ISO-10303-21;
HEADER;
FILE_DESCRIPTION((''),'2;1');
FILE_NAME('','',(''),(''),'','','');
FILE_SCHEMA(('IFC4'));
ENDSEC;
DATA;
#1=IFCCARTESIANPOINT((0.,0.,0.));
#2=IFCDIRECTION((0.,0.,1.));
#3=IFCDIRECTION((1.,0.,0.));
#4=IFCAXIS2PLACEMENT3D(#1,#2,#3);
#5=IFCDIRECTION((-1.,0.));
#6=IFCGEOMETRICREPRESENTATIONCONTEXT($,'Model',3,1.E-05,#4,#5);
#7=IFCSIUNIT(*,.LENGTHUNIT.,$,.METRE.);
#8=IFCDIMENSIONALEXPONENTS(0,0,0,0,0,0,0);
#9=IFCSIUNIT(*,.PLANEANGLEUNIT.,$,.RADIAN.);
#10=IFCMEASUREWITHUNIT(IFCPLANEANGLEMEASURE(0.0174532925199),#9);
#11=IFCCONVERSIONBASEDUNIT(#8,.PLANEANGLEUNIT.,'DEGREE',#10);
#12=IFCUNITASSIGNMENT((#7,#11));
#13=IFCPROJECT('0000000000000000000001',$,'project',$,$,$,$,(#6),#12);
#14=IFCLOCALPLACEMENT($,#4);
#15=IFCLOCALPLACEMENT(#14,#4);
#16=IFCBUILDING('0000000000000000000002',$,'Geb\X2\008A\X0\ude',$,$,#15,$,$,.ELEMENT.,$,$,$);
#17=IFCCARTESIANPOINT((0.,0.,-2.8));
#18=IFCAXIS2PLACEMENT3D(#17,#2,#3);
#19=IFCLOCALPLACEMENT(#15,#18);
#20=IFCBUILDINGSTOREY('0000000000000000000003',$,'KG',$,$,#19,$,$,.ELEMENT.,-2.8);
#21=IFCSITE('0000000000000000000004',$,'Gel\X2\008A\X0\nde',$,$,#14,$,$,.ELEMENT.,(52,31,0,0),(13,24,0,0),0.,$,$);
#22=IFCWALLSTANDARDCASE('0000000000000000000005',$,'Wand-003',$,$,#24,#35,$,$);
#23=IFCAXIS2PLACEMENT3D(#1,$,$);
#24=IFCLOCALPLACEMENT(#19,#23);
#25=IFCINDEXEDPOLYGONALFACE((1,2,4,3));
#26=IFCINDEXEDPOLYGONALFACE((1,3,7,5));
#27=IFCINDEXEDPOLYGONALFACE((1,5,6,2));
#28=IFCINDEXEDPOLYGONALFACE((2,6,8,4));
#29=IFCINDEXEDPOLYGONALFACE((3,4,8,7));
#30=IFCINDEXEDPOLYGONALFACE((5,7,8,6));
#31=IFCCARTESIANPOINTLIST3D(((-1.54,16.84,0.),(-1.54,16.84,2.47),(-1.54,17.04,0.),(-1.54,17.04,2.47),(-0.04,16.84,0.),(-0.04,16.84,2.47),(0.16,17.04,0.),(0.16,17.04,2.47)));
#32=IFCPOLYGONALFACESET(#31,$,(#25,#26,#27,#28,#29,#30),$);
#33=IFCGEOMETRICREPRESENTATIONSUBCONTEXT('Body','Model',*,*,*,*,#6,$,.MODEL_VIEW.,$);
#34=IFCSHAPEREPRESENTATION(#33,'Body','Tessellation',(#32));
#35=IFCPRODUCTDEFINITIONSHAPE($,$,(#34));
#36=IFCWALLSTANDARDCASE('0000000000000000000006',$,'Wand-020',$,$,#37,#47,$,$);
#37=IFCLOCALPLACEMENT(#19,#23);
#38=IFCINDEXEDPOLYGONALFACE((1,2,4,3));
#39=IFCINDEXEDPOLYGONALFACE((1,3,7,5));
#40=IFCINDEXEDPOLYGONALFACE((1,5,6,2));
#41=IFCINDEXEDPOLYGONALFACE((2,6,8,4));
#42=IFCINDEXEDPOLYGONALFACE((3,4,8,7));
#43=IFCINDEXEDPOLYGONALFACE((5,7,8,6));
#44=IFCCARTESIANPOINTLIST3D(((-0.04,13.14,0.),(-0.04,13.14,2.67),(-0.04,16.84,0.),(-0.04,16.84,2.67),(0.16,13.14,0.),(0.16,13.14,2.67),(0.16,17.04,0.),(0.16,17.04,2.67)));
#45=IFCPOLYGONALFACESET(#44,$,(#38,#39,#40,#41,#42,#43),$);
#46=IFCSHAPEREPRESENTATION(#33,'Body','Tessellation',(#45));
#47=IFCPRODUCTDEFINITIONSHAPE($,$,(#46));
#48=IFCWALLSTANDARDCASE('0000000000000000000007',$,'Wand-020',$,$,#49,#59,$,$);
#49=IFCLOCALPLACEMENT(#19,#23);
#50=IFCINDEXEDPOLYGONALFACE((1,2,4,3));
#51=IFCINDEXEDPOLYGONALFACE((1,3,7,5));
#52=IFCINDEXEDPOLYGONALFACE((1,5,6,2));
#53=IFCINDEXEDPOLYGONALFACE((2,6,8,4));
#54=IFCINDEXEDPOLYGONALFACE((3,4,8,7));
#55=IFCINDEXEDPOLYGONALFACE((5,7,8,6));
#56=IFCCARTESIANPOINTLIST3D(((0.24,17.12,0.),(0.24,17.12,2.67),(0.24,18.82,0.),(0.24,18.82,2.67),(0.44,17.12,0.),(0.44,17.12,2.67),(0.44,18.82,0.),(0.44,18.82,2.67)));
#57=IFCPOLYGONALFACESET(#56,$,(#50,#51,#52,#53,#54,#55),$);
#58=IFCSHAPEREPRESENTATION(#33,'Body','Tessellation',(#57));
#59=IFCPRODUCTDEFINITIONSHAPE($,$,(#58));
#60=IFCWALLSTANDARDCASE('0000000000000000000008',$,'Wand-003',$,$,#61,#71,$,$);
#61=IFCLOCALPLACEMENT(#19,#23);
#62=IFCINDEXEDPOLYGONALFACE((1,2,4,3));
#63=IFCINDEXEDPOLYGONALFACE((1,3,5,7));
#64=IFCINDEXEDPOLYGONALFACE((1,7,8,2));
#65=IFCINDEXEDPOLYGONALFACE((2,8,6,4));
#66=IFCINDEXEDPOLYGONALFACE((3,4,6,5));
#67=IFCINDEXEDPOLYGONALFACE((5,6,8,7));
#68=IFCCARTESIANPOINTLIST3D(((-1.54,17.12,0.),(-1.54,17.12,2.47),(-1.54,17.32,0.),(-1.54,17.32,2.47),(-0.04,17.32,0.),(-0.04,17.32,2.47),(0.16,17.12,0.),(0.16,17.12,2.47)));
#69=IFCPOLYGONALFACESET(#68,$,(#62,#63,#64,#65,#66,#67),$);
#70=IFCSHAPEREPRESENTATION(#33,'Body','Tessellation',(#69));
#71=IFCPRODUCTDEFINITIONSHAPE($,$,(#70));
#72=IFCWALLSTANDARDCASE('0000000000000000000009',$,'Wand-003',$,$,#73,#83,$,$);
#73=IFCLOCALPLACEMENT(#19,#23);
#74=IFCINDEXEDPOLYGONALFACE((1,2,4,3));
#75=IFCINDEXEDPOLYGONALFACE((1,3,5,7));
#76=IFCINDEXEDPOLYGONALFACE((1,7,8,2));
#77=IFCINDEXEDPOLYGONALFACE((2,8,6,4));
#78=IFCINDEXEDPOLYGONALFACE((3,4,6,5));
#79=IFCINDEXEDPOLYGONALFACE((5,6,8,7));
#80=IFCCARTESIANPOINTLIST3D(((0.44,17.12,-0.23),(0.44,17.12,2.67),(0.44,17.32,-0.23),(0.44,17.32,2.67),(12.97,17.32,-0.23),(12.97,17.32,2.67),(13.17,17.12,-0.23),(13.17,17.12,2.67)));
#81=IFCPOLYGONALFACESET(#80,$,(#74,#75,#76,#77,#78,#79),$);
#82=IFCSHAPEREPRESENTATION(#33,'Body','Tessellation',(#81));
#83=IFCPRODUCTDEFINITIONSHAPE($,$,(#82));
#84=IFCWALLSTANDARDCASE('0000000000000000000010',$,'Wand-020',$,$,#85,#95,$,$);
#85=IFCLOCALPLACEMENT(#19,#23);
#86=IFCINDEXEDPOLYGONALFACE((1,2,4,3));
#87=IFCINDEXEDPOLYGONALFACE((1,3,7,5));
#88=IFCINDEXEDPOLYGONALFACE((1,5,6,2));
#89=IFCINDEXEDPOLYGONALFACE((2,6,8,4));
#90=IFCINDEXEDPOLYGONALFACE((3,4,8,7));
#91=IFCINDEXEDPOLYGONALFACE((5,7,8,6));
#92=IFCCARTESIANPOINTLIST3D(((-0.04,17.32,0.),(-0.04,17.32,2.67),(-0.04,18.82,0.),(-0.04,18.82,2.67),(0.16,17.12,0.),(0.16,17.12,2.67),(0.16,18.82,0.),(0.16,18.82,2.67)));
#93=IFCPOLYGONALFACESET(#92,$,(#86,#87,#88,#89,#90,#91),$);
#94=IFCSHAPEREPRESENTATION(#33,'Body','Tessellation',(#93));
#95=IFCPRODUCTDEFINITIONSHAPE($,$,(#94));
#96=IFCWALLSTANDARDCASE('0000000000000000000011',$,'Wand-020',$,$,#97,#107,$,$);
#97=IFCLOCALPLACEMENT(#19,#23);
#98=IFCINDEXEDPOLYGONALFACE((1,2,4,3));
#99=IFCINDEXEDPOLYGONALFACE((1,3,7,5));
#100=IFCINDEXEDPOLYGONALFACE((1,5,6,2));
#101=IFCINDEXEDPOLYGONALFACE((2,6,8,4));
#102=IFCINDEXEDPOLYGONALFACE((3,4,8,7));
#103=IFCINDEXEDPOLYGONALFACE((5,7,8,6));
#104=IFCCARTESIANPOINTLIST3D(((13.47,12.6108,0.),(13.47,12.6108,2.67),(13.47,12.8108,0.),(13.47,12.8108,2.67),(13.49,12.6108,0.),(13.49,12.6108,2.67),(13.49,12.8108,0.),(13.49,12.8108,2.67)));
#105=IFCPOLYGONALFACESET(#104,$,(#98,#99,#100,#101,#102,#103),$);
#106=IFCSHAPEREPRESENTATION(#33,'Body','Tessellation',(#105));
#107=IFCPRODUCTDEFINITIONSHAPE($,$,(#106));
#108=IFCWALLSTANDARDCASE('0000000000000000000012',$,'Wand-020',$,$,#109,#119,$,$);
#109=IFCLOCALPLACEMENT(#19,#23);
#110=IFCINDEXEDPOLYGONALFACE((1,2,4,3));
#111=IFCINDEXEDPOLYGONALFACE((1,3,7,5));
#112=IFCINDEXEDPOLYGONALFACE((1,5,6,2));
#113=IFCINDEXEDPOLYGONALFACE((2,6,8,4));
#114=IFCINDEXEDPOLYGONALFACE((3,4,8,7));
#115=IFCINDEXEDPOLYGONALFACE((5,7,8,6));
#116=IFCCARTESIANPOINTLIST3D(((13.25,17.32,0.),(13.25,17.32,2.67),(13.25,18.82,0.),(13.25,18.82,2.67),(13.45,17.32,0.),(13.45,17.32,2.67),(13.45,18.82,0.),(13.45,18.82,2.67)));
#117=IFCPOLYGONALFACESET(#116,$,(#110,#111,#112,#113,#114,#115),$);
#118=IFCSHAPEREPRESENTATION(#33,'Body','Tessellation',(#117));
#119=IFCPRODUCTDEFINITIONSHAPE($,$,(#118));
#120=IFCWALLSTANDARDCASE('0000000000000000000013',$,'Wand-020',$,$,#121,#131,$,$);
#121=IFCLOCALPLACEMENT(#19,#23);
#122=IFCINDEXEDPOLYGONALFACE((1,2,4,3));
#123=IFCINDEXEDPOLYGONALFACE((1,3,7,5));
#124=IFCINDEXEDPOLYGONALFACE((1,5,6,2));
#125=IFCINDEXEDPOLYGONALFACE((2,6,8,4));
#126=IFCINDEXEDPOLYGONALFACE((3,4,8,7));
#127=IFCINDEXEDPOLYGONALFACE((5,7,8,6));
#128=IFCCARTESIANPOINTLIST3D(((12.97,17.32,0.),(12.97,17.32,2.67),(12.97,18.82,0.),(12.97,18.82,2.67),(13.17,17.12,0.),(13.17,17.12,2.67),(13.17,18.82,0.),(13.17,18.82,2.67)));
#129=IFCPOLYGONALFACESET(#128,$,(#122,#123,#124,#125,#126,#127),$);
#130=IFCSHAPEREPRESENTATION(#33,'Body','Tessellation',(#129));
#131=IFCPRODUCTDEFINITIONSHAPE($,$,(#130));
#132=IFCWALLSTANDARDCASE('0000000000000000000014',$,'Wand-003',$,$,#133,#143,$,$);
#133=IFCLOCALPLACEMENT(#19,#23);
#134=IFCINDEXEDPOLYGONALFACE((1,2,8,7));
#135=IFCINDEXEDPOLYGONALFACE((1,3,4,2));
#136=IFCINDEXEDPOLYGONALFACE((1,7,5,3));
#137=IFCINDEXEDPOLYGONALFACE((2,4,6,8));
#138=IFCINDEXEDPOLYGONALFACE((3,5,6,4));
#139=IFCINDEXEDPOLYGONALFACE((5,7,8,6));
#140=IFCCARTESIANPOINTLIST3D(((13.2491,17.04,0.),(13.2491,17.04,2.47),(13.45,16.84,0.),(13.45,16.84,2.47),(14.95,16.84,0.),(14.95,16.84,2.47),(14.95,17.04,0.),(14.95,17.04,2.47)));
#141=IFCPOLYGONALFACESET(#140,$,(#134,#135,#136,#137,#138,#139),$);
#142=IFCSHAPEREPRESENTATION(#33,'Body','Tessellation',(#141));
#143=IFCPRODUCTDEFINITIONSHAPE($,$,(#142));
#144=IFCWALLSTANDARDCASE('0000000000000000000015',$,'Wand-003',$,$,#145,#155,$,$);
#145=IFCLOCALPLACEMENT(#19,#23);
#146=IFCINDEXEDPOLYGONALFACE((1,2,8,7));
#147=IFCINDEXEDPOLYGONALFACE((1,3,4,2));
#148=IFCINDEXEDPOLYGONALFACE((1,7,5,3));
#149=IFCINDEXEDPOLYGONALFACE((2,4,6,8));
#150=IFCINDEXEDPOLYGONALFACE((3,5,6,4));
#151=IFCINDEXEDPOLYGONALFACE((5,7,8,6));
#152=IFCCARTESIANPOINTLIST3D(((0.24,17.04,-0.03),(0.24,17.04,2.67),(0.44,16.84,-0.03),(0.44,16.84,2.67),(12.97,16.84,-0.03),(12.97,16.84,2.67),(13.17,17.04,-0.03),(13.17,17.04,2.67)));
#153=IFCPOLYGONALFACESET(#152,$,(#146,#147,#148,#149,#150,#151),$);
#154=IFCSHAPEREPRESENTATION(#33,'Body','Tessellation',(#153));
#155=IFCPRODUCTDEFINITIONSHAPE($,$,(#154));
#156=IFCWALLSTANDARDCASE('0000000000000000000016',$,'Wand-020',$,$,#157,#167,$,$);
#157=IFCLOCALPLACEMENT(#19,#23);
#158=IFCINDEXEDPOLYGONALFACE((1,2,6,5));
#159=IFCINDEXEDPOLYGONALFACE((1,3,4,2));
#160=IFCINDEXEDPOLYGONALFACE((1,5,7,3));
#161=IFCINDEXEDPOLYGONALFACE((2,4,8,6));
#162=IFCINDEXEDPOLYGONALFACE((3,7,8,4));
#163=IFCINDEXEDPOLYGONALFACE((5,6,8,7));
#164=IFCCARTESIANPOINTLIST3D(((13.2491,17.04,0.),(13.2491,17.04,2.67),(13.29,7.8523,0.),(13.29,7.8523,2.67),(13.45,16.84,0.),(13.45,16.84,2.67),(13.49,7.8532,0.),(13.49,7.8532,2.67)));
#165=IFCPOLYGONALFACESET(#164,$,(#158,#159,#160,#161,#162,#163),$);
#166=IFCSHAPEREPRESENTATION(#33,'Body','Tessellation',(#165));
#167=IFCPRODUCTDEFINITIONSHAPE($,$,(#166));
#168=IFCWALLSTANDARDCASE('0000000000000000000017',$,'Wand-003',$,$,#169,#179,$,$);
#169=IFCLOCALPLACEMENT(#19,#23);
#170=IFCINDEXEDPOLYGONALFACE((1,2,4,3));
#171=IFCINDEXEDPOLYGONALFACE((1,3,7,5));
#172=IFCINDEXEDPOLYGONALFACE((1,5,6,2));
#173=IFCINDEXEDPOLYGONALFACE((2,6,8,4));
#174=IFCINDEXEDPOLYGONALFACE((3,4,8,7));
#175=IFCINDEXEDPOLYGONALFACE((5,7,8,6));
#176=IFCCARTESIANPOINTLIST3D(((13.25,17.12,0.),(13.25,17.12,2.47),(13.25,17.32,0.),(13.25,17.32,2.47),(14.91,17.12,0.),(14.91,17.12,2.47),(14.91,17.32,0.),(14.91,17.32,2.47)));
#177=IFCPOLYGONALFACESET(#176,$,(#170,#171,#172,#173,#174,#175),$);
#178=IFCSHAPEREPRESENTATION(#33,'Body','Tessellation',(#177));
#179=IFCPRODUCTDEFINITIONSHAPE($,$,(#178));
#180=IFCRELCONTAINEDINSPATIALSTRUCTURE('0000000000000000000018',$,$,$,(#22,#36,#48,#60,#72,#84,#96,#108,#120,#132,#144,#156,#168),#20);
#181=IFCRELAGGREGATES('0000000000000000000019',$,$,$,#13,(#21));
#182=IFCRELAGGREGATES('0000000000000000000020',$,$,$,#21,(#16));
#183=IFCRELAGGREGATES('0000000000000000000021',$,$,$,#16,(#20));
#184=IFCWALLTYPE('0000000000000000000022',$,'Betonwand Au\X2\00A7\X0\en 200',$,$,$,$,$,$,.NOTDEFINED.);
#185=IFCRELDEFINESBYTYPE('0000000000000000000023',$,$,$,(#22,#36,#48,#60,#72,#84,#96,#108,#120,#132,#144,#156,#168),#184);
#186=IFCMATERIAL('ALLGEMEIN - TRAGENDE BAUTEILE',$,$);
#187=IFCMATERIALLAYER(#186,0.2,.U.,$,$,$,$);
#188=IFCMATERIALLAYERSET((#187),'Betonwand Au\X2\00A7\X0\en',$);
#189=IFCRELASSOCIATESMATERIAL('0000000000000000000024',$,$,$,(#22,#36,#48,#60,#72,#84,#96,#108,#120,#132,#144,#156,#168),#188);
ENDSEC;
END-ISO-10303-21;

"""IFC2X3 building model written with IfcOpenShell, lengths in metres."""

from ifc_helpers import new_model, entity, si_unit, converted_unit, direction, frame, origin_with_axes, place, context, subcontext, project, spatial, polyline, outline, extrude, material, layer, layer_set, layer_usage, type_object, element, save


model = new_model("IFC2X3")

# Units and contexts
model_context = context("Model", 3, precision=1e-05, world=origin_with_axes(), true_north=direction((-1.0, 0.0)))
body_context = subcontext(model_context, "Body", "Model", "MODEL_VIEW")
ifc_project = project(units=[si_unit("LENGTHUNIT", "METRE"), converted_unit("PLANEANGLEUNIT", "DEGREE", entity("IfcPlaneAngleMeasure", 0.0174532925199), si_unit("PLANEANGLEUNIT", "RADIAN"), dimensions=[0, 0, 0, 0, 0, 0, 0])], contexts=[model_context])

# Site, building, storey
site_placement = place(None, origin_with_axes())
site = spatial("IfcSite", under=ifc_project, at=site_placement, Name="Gel\u008ande", CompositionType="ELEMENT", RefLatitude=(52, 31, 0, 0), RefLongitude=(13, 24, 0, 0), RefElevation=0.0)
building_placement = place(site_placement, origin_with_axes())
building = spatial("IfcBuilding", under=site, at=building_placement, Name="Geb\u008aude", CompositionType="ELEMENT")
storey_placement = place(building_placement, frame((0.0, 0.0, -2.8), z_axis=(0.0, 0.0, 1.0), x_axis=(1.0, 0.0, 0.0)))
storey = spatial("IfcBuildingStorey", under=building, at=storey_placement, Name="KG", CompositionType="ELEMENT", Elevation=-2.8)

# Shared definitions
ifc_material_1 = material(Name="ALLGEMEIN - TRAGENDE BAUTEILE")

# Walls
ifc_layer_1 = layer(ifc_material_1, 0.2, ventilated="UNKNOWN")
ifc_layer_set_1 = layer_set([ifc_layer_1], Name="Betonwand Au§en")
wall_type_1 = type_object("IfcWallType", Name="Betonwand Au§en 200", PredefinedType="NOTDEFINED")
ifc_layer_usage_1 = layer_usage(ifc_layer_set_1, "AXIS2", "POSITIVE", 0.0)
wall_1_placement = place(storey_placement, frame((-1.54, 16.84, 0.0), z_axis=(0.0, 0.0, 1.0), x_axis=(1.0, 0.0, 0.0)))
element("IfcWallStandardCase", 1, at=wall_1_placement, inside=storey, type_object=wall_type_1, material=ifc_layer_usage_1, Name="Wand-003", context=body_context, shape_type="SweptSolid", body=[
    extrude(outline(polyline([(0.0, 0.0), (1.5, 0.0), (1.7, 0.2), (0.0, 0.2), (0.0, 0.0)])), origin_with_axes(), (0.0, 0.0, 1.0), 2.47),
])
ifc_layer_usage_2 = layer_usage(ifc_layer_set_1, "AXIS2", "POSITIVE", -0.2)
wall_2_placement = place(storey_placement, frame((-0.04, 13.14, 0.0), z_axis=(0.0, 0.0, 1.0), x_axis=(0.0, 1.0, 0.0)))
element("IfcWallStandardCase", 2, at=wall_2_placement, inside=storey, type_object=wall_type_1, material=ifc_layer_usage_2, Name="Wand-020", context=body_context, shape_type="SweptSolid", body=[
    extrude(outline(polyline([(0.0, -0.2), (3.9, -0.2), (3.7, 0.0), (0.0, 0.0), (0.0, -0.2)])), origin_with_axes(), (0.0, 0.0, 1.0), 2.67),
])
ifc_layer_usage_3 = layer_usage(ifc_layer_set_1, "AXIS2", "NEGATIVE", 0.2)
wall_3_placement = place(storey_placement, frame((0.44, 17.12, 0.0), z_axis=(0.0, 0.0, 1.0), x_axis=(0.0, 1.0, 0.0)))
element("IfcWallStandardCase", 3, at=wall_3_placement, inside=storey, type_object=wall_type_1, material=ifc_layer_usage_3, Name="Wand-020", context=body_context, shape_type="SweptSolid", body=[
    extrude(outline(polyline([(0.0, 0.0), (1.7, 0.0), (1.7, 0.2), (0.0, 0.2), (0.0, 0.0)])), origin_with_axes(), (0.0, 0.0, 1.0), 2.67),
])
ifc_layer_usage_4 = layer_usage(ifc_layer_set_1, "AXIS2", "POSITIVE", 0.0)
wall_4_placement = place(storey_placement, frame((-1.54, 17.12, 0.0), z_axis=(0.0, 0.0, 1.0), x_axis=(1.0, 0.0, 0.0)))
element("IfcWallStandardCase", 4, at=wall_4_placement, inside=storey, type_object=wall_type_1, material=ifc_layer_usage_4, Name="Wand-003", context=body_context, shape_type="SweptSolid", body=[
    extrude(outline(polyline([(0.0, 0.0), (1.7, 0.0), (1.5, 0.2), (0.0, 0.2), (0.0, 0.0)])), origin_with_axes(), (0.0, 0.0, 1.0), 2.47),
])
ifc_layer_usage_5 = layer_usage(ifc_layer_set_1, "AXIS2", "NEGATIVE", 0.0)
wall_5_placement = place(storey_placement, frame((0.44, 17.32, -0.23), z_axis=(0.0, 0.0, 1.0), x_axis=(1.0, 0.0, 0.0)))
element("IfcWallStandardCase", 5, at=wall_5_placement, inside=storey, type_object=wall_type_1, material=ifc_layer_usage_5, Name="Wand-003", context=body_context, shape_type="SweptSolid", body=[
    extrude(outline(polyline([(0.0, -0.2), (12.73, -0.2), (12.53, 0.0), (0.0, 0.0), (0.0, -0.2)])), origin_with_axes(), (0.0, 0.0, 1.0), 2.9),
])
ifc_layer_usage_6 = layer_usage(ifc_layer_set_1, "AXIS2", "NEGATIVE", 0.2)
wall_6_placement = place(storey_placement, frame((0.16, 17.12, 0.0), z_axis=(0.0, 0.0, 1.0), x_axis=(0.0, 1.0, 0.0)))
element("IfcWallStandardCase", 6, at=wall_6_placement, inside=storey, type_object=wall_type_1, material=ifc_layer_usage_6, Name="Wand-020", context=body_context, shape_type="SweptSolid", body=[
    extrude(outline(polyline([(0.0, 0.0), (1.7, 0.0), (1.7, 0.2), (0.2, 0.2), (0.0, 0.0)])), origin_with_axes(), (0.0, 0.0, 1.0), 2.67),
])
ifc_layer_usage_7 = layer_usage(ifc_layer_set_1, "AXIS2", "NEGATIVE", 0.2)
wall_7_placement = place(storey_placement, frame((13.49, 12.8108, 0.0), z_axis=(0.0, 0.0, 1.0), x_axis=(-1.0, 0.0, 0.0)))
element("IfcWallStandardCase", 7, at=wall_7_placement, inside=storey, type_object=wall_type_1, material=ifc_layer_usage_7, Name="Wand-020", context=body_context, shape_type="SweptSolid", body=[
    extrude(outline(polyline([(0.0, 0.0), (0.02, 0.0), (0.02, 0.2), (0.0, 0.2), (0.0, 0.0)])), origin_with_axes(), (0.0, 0.0, 1.0), 2.67),
])
ifc_layer_usage_8 = layer_usage(ifc_layer_set_1, "AXIS2", "POSITIVE", -0.2)
wall_8_placement = place(storey_placement, frame((13.45, 18.82, 0.0), z_axis=(0.0, 0.0, 1.0), x_axis=(0.0, -1.0, 0.0)))
element("IfcWallStandardCase", 8, at=wall_8_placement, inside=storey, type_object=wall_type_1, material=ifc_layer_usage_8, Name="Wand-020", context=body_context, shape_type="SweptSolid", body=[
    extrude(outline(polyline([(0.0, -0.2), (1.5, -0.2), (1.5, 0.0), (0.0, 0.0), (0.0, -0.2)])), origin_with_axes(), (0.0, 0.0, 1.0), 2.67),
])
ifc_layer_usage_9 = layer_usage(ifc_layer_set_1, "AXIS2", "NEGATIVE", 0.0)
wall_9_placement = place(storey_placement, frame((12.97, 17.32, 0.0), z_axis=(0.0, 0.0, 1.0), x_axis=(0.0, 1.0, 0.0)))
element("IfcWallStandardCase", 9, at=wall_9_placement, inside=storey, type_object=wall_type_1, material=ifc_layer_usage_9, Name="Wand-020", context=body_context, shape_type="SweptSolid", body=[
    extrude(outline(polyline([(-0.2, -0.2), (1.5, -0.2), (1.5, 0.0), (0.0, 0.0), (-0.2, -0.2)])), origin_with_axes(), (0.0, 0.0, 1.0), 2.67),
])
ifc_layer_usage_10 = layer_usage(ifc_layer_set_1, "AXIS2", "POSITIVE", 0.0)
wall_10_placement = place(storey_placement, frame((13.45, 16.84, 0.0), z_axis=(0.0, 0.0, 1.0), x_axis=(1.0, 0.0, 0.0)))
element("IfcWallStandardCase", 10, at=wall_10_placement, inside=storey, type_object=wall_type_1, material=ifc_layer_usage_10, Name="Wand-003", context=body_context, shape_type="SweptSolid", body=[
    extrude(outline(polyline([(0.0, 0.0), (1.5, 0.0), (1.5, 0.2), (-0.2009, 0.2), (0.0, 0.0)])), origin_with_axes(), (0.0, 0.0, 1.0), 2.47),
])
ifc_layer_usage_11 = layer_usage(ifc_layer_set_1, "AXIS2", "POSITIVE", 0.0)
wall_11_placement = place(storey_placement, frame((0.44, 16.84, -0.03), z_axis=(0.0, 0.0, 1.0), x_axis=(1.0, 0.0, 0.0)))
element("IfcWallStandardCase", 11, at=wall_11_placement, inside=storey, type_object=wall_type_1, material=ifc_layer_usage_11, Name="Wand-003", context=body_context, shape_type="SweptSolid", body=[
    extrude(outline(polyline([(0.0, 0.0), (12.53, 0.0), (12.73, 0.2), (-0.2, 0.2), (0.0, 0.0)])), origin_with_axes(), (0.0, 0.0, 1.0), 2.7),
])
ifc_layer_usage_12 = layer_usage(ifc_layer_set_1, "AXIS2", "NEGATIVE", 0.2)
wall_12_placement = place(storey_placement, frame((13.49, 7.8532, 0.0), z_axis=(0.0, 0.0, 1.0), x_axis=(-0.004451, 0.99999, 0.0)))
element("IfcWallStandardCase", 12, at=wall_12_placement, inside=storey, type_object=wall_type_1, material=ifc_layer_usage_12, Name="Wand-020", context=body_context, shape_type="SweptSolid", body=[
    extrude(outline(polyline([(0.0, 0.0), (8.9869, 0.0), (9.1878, 0.2), (0.0, 0.2), (0.0, 0.0)])), origin_with_axes(), (0.0, 0.0, 1.0), 2.67),
])
ifc_layer_usage_13 = layer_usage(ifc_layer_set_1, "AXIS2", "POSITIVE", 0.0)
wall_13_placement = place(storey_placement, frame((13.25, 17.12, 0.0), z_axis=(0.0, 0.0, 1.0), x_axis=(1.0, 0.0, 0.0)))
element("IfcWallStandardCase", 13, at=wall_13_placement, inside=storey, type_object=wall_type_1, material=ifc_layer_usage_13, Name="Wand-003", context=body_context, shape_type="SweptSolid", body=[
    extrude(outline(polyline([(0.0, 0.0), (1.66, 0.0), (1.66, 0.2), (0.0, 0.2), (0.0, 0.0)])), origin_with_axes(), (0.0, 0.0, 1.0), 2.47),
])

save(model, "model.ifc")
